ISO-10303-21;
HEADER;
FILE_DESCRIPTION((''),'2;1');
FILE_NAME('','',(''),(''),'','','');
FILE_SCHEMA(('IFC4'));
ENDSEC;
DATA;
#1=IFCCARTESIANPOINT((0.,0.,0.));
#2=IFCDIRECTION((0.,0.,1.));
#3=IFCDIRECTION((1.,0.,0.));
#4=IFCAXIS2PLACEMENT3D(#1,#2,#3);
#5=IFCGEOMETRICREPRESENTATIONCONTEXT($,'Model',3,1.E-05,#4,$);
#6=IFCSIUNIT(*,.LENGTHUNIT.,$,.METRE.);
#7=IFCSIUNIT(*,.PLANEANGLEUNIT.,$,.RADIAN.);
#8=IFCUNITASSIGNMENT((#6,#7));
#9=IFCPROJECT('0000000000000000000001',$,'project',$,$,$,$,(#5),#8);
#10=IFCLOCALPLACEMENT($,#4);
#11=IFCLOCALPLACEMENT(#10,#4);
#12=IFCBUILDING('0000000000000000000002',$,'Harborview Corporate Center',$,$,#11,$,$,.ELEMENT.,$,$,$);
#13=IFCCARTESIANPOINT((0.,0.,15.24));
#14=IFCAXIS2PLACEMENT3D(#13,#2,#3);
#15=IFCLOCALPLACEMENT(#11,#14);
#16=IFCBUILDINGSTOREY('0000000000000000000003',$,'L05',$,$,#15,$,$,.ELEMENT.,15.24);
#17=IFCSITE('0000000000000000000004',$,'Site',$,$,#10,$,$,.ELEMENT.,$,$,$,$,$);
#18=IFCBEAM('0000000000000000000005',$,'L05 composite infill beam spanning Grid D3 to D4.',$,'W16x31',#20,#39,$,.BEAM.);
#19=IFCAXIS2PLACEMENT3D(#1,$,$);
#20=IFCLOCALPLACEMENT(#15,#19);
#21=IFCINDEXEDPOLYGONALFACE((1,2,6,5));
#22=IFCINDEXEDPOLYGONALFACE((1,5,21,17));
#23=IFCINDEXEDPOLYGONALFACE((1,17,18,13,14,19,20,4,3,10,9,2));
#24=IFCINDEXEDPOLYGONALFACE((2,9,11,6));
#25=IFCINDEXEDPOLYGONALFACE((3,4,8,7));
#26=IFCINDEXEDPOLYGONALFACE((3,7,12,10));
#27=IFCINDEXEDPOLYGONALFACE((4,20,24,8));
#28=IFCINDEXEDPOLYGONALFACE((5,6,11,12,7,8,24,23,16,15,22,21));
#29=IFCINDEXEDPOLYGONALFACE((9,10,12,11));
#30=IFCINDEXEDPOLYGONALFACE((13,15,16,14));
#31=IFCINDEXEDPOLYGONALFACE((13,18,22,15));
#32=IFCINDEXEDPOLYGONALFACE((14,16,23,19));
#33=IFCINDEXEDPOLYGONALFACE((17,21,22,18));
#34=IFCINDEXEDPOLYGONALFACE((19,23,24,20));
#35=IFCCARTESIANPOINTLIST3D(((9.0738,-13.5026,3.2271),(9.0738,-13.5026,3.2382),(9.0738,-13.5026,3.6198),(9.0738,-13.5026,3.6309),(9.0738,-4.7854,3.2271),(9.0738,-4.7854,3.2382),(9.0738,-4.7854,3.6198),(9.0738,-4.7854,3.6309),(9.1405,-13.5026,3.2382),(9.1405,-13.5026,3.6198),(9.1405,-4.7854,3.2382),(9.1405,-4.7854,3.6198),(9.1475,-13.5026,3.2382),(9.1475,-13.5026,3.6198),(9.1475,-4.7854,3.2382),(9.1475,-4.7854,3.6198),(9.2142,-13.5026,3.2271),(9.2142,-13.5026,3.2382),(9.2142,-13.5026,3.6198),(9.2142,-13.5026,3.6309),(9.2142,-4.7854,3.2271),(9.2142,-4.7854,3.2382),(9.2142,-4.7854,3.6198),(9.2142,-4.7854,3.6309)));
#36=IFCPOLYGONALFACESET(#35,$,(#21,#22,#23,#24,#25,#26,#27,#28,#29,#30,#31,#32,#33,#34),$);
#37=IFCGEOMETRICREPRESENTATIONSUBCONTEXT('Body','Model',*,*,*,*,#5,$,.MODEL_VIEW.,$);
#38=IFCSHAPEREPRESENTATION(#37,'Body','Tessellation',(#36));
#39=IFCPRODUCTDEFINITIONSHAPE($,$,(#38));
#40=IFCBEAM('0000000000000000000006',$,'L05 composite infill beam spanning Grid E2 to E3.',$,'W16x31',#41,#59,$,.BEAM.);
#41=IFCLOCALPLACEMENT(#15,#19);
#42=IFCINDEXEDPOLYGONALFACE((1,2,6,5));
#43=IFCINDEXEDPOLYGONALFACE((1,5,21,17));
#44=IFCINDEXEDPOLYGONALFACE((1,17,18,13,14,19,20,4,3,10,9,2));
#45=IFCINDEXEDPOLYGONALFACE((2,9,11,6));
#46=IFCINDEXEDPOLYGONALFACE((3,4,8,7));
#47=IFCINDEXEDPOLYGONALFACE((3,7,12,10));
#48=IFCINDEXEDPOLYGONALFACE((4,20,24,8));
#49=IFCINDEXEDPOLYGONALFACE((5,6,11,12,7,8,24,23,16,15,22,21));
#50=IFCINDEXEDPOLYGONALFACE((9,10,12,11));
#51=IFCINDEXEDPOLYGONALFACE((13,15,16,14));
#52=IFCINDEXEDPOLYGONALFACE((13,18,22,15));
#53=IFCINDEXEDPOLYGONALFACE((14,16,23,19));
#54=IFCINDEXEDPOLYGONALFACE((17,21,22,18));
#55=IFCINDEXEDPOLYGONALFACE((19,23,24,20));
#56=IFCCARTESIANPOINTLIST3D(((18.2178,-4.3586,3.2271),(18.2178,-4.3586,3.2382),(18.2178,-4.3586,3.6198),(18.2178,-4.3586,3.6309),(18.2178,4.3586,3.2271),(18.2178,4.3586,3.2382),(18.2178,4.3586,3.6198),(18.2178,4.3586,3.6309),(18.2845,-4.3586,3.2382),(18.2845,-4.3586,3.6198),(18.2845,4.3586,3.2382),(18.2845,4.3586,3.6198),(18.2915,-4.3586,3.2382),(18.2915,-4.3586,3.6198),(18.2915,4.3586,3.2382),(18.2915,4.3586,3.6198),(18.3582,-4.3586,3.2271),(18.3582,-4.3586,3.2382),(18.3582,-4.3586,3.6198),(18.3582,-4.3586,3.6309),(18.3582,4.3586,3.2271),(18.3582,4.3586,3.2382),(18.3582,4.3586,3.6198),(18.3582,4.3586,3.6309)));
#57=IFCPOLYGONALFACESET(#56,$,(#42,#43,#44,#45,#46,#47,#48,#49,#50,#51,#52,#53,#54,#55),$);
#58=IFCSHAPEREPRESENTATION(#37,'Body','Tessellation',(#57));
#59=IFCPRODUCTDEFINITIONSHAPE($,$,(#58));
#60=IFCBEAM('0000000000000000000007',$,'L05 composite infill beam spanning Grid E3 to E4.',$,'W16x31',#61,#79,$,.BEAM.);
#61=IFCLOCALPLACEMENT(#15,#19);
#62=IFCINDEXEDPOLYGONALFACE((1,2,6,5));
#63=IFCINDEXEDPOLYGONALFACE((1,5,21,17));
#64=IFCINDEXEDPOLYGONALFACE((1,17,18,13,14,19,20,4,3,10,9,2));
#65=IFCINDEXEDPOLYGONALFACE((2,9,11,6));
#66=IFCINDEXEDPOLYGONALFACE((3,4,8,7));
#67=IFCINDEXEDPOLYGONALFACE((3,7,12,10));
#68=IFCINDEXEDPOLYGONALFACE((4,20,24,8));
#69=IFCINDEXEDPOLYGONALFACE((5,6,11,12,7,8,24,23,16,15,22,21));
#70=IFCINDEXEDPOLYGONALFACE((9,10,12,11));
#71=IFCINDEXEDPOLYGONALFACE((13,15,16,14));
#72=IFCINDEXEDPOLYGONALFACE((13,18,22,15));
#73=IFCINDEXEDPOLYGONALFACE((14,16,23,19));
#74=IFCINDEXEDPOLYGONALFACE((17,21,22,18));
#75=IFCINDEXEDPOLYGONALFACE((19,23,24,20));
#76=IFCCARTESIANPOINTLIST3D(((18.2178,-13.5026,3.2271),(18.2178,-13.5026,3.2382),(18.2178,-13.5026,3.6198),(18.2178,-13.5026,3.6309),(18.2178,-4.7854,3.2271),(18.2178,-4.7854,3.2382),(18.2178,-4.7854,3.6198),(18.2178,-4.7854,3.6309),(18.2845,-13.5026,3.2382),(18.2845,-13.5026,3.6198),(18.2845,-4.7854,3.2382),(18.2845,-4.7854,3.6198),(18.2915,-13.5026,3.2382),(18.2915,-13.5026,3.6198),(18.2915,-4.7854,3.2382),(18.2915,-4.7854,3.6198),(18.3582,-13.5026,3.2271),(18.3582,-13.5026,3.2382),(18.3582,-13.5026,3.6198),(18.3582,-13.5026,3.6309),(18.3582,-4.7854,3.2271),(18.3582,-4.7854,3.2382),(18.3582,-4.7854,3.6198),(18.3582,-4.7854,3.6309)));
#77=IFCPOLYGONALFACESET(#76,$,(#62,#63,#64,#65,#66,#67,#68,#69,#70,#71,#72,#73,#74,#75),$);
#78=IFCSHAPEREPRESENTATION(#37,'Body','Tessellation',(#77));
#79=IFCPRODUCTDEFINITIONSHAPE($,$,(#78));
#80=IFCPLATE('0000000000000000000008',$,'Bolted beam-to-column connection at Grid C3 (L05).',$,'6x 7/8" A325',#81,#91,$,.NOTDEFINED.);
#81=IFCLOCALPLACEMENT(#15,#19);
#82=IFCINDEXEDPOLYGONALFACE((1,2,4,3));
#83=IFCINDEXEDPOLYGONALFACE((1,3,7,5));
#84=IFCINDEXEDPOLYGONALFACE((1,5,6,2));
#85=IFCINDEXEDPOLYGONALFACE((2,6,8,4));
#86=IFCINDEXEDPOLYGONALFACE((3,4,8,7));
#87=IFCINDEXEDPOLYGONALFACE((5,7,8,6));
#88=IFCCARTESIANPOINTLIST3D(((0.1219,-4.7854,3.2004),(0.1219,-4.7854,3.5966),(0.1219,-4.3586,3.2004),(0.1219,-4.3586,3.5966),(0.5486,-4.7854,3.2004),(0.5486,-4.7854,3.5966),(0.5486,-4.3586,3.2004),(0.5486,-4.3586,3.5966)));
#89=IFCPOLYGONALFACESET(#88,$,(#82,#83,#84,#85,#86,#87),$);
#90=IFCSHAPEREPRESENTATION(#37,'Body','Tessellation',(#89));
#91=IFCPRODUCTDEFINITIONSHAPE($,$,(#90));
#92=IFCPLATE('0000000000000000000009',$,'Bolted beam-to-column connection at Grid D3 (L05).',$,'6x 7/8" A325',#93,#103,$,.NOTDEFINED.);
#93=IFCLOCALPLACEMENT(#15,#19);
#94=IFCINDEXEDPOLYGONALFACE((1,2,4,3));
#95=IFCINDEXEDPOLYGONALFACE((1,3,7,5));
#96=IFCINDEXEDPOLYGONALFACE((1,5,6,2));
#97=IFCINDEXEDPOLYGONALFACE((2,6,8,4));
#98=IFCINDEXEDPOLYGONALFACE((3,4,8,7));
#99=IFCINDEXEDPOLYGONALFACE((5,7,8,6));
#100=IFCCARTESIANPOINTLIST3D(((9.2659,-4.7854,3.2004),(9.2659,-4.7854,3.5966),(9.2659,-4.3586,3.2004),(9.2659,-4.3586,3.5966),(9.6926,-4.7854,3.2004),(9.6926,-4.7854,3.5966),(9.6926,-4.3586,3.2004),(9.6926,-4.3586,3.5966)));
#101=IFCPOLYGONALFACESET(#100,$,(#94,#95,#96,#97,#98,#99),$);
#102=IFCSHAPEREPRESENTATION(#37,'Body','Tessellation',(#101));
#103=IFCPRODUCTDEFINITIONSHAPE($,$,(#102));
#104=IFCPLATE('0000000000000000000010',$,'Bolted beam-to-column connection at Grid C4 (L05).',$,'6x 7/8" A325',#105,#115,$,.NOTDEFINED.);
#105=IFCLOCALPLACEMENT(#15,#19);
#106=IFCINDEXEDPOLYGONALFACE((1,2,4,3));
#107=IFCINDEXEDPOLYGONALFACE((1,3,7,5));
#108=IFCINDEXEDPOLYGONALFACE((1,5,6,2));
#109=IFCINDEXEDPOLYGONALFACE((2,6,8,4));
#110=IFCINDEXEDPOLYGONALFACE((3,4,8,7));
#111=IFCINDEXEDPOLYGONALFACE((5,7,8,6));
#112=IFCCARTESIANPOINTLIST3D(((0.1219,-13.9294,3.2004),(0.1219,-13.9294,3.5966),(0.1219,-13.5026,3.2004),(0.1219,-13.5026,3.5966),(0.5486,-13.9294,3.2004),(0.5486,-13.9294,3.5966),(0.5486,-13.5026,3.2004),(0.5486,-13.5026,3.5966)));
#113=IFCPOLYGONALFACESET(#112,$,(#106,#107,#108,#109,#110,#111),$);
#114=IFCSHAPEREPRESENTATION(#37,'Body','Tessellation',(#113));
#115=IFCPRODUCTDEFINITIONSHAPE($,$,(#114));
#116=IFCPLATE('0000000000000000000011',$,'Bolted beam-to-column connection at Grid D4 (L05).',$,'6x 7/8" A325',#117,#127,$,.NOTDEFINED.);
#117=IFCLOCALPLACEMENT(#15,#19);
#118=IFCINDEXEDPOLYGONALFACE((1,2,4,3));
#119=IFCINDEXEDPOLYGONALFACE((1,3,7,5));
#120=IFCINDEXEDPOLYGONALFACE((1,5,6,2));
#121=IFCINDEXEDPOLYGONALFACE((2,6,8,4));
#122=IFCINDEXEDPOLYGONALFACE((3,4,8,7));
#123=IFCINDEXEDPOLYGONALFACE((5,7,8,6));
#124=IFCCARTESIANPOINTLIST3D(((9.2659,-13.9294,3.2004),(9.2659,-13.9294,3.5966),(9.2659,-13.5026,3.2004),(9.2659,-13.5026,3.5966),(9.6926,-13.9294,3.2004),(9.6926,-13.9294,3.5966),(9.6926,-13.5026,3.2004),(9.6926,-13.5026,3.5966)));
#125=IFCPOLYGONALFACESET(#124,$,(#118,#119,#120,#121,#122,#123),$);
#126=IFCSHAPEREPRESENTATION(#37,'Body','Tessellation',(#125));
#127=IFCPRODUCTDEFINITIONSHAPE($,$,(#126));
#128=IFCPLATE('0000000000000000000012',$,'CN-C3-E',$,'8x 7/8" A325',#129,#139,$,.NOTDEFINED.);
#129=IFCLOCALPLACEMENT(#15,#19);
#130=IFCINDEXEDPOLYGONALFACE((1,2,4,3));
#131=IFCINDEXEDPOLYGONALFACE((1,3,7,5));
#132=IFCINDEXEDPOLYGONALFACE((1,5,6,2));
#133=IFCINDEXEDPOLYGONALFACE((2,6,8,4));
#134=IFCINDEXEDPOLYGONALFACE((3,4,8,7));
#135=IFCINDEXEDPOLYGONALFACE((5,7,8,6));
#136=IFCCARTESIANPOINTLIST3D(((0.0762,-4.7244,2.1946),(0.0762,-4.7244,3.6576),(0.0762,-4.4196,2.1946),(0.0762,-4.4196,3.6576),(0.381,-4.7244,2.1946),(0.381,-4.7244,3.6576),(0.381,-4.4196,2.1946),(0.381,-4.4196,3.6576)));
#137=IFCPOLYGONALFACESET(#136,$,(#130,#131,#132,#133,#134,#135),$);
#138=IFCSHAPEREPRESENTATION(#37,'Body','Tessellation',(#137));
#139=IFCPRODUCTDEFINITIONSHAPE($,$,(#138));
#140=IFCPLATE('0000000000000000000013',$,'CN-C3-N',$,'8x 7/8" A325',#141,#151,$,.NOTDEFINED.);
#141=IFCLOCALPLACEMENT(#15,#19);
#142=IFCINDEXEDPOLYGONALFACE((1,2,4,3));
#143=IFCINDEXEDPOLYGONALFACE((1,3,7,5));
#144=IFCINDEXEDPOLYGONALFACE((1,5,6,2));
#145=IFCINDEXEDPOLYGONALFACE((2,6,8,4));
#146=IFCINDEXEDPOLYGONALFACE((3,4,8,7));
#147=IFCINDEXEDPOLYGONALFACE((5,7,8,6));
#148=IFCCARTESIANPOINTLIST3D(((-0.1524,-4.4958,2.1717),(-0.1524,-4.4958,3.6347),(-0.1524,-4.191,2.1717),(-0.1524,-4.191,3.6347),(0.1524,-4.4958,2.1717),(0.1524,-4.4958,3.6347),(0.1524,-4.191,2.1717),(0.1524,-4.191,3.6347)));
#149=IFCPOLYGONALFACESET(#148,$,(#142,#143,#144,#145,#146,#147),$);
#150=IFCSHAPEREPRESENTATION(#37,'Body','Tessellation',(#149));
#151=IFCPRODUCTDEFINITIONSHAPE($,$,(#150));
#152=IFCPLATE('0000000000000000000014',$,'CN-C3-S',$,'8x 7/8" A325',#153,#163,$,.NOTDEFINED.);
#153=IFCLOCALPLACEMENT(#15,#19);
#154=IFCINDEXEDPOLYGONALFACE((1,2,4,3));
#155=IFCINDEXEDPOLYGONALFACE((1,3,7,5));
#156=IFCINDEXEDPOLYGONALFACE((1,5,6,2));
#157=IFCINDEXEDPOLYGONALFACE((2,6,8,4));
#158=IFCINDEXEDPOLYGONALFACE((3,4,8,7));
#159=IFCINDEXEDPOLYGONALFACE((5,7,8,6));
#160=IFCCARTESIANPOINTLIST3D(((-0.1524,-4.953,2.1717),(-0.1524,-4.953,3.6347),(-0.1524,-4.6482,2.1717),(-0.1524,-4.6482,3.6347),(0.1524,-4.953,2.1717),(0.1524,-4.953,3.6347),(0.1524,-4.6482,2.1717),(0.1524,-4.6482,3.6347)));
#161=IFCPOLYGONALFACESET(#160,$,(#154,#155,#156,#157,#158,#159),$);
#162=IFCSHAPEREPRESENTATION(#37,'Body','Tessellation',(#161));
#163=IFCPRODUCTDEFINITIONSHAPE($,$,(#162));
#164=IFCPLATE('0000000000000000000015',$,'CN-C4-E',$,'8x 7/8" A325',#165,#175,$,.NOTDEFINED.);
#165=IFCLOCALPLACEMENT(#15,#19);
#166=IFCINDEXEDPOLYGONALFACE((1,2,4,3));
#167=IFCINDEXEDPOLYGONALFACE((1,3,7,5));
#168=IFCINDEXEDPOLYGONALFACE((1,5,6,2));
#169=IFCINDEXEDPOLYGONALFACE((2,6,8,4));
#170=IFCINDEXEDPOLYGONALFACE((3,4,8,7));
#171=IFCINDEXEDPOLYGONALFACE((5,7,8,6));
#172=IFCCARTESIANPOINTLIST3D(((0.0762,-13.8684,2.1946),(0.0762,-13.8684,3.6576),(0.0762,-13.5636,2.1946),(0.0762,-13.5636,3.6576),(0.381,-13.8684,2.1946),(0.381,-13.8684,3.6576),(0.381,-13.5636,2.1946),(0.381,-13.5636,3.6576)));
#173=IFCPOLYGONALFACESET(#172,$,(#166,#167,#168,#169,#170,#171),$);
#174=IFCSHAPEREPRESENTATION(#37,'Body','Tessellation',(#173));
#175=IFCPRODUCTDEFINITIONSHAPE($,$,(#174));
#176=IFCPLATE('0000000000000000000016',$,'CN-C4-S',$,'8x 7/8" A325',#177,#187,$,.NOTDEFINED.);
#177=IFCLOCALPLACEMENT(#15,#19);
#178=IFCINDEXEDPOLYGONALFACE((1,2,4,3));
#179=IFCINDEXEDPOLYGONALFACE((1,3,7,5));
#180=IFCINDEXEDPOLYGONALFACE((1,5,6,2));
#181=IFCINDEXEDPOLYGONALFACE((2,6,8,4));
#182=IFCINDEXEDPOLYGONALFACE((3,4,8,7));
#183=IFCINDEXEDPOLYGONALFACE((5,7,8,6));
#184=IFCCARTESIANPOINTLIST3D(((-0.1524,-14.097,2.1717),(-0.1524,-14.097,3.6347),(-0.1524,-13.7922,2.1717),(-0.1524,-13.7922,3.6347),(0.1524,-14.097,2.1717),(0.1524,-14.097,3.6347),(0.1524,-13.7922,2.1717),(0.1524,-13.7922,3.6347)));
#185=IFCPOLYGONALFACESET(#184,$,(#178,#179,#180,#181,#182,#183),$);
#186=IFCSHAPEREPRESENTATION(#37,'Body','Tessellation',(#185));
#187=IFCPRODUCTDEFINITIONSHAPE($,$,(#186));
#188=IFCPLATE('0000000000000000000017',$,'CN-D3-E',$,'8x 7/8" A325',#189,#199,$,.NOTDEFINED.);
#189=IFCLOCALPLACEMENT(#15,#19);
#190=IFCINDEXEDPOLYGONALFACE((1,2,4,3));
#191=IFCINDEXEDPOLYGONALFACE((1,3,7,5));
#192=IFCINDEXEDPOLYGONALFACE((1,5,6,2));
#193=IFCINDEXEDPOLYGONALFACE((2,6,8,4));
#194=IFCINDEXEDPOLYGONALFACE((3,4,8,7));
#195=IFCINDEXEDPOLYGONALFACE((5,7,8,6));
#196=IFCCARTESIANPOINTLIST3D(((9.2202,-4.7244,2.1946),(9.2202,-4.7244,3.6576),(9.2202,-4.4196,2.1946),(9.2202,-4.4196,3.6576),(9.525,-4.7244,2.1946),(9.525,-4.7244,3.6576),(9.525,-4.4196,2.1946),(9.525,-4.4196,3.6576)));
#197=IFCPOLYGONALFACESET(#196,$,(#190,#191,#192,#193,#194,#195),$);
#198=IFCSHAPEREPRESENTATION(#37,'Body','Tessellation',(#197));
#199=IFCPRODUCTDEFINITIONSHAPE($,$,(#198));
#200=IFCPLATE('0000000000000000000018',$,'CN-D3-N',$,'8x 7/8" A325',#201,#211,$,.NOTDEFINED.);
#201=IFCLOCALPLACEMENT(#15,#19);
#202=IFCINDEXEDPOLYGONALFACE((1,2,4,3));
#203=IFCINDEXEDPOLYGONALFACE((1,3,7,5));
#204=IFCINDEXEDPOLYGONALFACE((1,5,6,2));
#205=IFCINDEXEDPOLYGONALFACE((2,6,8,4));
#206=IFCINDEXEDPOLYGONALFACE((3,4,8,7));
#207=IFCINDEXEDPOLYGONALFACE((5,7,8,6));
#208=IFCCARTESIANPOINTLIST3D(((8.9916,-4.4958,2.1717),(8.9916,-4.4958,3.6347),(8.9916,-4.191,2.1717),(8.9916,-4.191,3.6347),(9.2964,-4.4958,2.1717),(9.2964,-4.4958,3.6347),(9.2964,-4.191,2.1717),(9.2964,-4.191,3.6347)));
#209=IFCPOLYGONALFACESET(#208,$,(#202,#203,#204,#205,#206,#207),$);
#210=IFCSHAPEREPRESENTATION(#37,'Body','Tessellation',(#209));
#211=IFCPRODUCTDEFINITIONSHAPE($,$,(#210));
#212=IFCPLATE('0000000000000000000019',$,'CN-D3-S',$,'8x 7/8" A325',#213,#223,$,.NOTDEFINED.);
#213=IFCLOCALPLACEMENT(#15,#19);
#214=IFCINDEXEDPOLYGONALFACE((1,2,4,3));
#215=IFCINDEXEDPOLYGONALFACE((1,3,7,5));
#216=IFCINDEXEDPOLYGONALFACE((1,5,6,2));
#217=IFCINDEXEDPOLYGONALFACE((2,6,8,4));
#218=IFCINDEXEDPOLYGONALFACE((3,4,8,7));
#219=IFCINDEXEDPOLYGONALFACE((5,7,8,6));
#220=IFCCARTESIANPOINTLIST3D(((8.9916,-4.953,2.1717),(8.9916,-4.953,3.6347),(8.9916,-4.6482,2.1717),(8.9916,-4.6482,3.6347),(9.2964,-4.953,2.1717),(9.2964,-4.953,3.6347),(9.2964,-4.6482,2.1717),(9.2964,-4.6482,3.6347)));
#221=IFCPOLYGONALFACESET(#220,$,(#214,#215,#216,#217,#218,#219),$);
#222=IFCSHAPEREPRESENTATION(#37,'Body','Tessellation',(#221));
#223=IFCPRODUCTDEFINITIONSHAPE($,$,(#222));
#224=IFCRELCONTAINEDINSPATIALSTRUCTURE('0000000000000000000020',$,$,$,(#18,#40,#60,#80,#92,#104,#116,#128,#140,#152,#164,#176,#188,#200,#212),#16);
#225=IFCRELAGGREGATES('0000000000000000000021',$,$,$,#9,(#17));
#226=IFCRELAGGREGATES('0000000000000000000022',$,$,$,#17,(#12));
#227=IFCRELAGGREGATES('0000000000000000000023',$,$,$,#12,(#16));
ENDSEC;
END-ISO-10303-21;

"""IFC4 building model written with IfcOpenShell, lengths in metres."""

from ifc_helpers import new_model, si_unit, frame, origin_with_axes, place, context, subcontext, project, spatial, rectangle, i_section, extrude, element, save


model = new_model("IFC4")

# Units and contexts
model_context = context("Model", 3, precision=1e-05, world=origin_with_axes())
body_context = subcontext(model_context, "Body", "Model", "MODEL_VIEW")
ifc_project = project(units=[si_unit("LENGTHUNIT", "METRE"), si_unit("PLANEANGLEUNIT", "RADIAN")], contexts=[model_context])

# Site, building, storey
site_placement = place(None, origin_with_axes())
site = spatial("IfcSite", under=ifc_project, at=site_placement, Name="Site", CompositionType="ELEMENT")
building_placement = place(site_placement, origin_with_axes())
building = spatial("IfcBuilding", under=site, at=building_placement, Name="Harborview Corporate Center", CompositionType="ELEMENT")
storey_placement = place(building_placement, frame((0.0, 0.0, 15.24), z_axis=(0.0, 0.0, 1.0), x_axis=(1.0, 0.0, 0.0)))
storey = spatial("IfcBuildingStorey", under=building, at=storey_placement, Name="L05", CompositionType="ELEMENT", Elevation=15.24)

# Beams
beam_1_placement = place(storey_placement, frame((9.144, -13.5026, 3.429), z_axis=(0.0, 1.0, 0.0), x_axis=(-1.0, 0.0, 0.0)))
element("IfcBeam", 1, at=beam_1_placement, inside=storey, Name="L05 composite infill beam spanning Grid D3 to D4.", ObjectType="W16x31", PredefinedType="BEAM", context=body_context, shape_type="SweptSolid", body=[
    extrude(i_section(OverallWidth=0.1405, OverallDepth=0.4039, WebThickness=0.007, FlangeThickness=0.0112), origin_with_axes(), (0.0, 0.0, 1.0), 8.7173),
])
beam_2_placement = place(storey_placement, frame((18.288, -4.3586, 3.429), z_axis=(0.0, 1.0, 0.0), x_axis=(-1.0, 0.0, 0.0)))
element("IfcBeam", 2, at=beam_2_placement, inside=storey, Name="L05 composite infill beam spanning Grid E2 to E3.", ObjectType="W16x31", PredefinedType="BEAM", context=body_context, shape_type="SweptSolid", body=[
    extrude(i_section(OverallWidth=0.1405, OverallDepth=0.4039, WebThickness=0.007, FlangeThickness=0.0112), origin_with_axes(), (0.0, 0.0, 1.0), 8.7173),
])
beam_3_placement = place(storey_placement, frame((18.288, -13.5026, 3.429), z_axis=(0.0, 1.0, 0.0), x_axis=(-1.0, 0.0, 0.0)))
element("IfcBeam", 3, at=beam_3_placement, inside=storey, Name="L05 composite infill beam spanning Grid E3 to E4.", ObjectType="W16x31", PredefinedType="BEAM", context=body_context, shape_type="SweptSolid", body=[
    extrude(i_section(OverallWidth=0.1405, OverallDepth=0.4039, WebThickness=0.007, FlangeThickness=0.0112), origin_with_axes(), (0.0, 0.0, 1.0), 8.7173),
])

# Plates
plate_1_placement = place(storey_placement, frame((0.3353, -4.572, 3.2004), z_axis=(0.0, 0.0, 1.0), x_axis=(1.0, 0.0, 0.0)))
element("IfcPlate", 4, at=plate_1_placement, inside=storey, Name="Bolted beam-to-column connection at Grid C3 (L05).", ObjectType="6x 7/8\" A325", PredefinedType="NOTDEFINED", context=body_context, shape_type="SweptSolid", body=[
    extrude(rectangle(XDim=0.4267, YDim=0.4267), origin_with_axes(), (0.0, 0.0, 1.0), 0.3962),
])
plate_2_placement = place(storey_placement, frame((9.4793, -4.572, 3.2004), z_axis=(0.0, 0.0, 1.0), x_axis=(1.0, 0.0, 0.0)))
element("IfcPlate", 5, at=plate_2_placement, inside=storey, Name="Bolted beam-to-column connection at Grid D3 (L05).", ObjectType="6x 7/8\" A325", PredefinedType="NOTDEFINED", context=body_context, shape_type="SweptSolid", body=[
    extrude(rectangle(XDim=0.4267, YDim=0.4267), origin_with_axes(), (0.0, 0.0, 1.0), 0.3962),
])
plate_3_placement = place(storey_placement, frame((0.3353, -13.716, 3.2004), z_axis=(0.0, 0.0, 1.0), x_axis=(1.0, 0.0, 0.0)))
element("IfcPlate", 6, at=plate_3_placement, inside=storey, Name="Bolted beam-to-column connection at Grid C4 (L05).", ObjectType="6x 7/8\" A325", PredefinedType="NOTDEFINED", context=body_context, shape_type="SweptSolid", body=[
    extrude(rectangle(XDim=0.4267, YDim=0.4267), origin_with_axes(), (0.0, 0.0, 1.0), 0.3962),
])
plate_4_placement = place(storey_placement, frame((9.4793, -13.716, 3.2004), z_axis=(0.0, 0.0, 1.0), x_axis=(1.0, 0.0, 0.0)))
element("IfcPlate", 7, at=plate_4_placement, inside=storey, Name="Bolted beam-to-column connection at Grid D4 (L05).", ObjectType="6x 7/8\" A325", PredefinedType="NOTDEFINED", context=body_context, shape_type="SweptSolid", body=[
    extrude(rectangle(XDim=0.4267, YDim=0.4267), origin_with_axes(), (0.0, 0.0, 1.0), 0.3962),
])
for number, where, z_axis, x_axis, name in (
    (8, (0.2286, -4.572, 2.1946), (0.0, 0.0, 1.0), (1.0, 0.0, 0.0), "CN-C3-E"),
    (9, (0.0, -4.3434, 2.1717), (0.0, 0.0, 1.0), (1.0, 0.0, 0.0), "CN-C3-N"),
    (10, (0.0, -4.8006, 2.1717), (0.0, 0.0, 1.0), (1.0, 0.0, 0.0), "CN-C3-S"),
    (11, (0.2286, -13.716, 2.1946), (0.0, 0.0, 1.0), (1.0, 0.0, 0.0), "CN-C4-E"),
    (12, (0.0, -13.9446, 2.1717), (0.0, 0.0, 1.0), (1.0, 0.0, 0.0), "CN-C4-S"),
):
    element("IfcPlate", number, at=place(storey_placement, frame(where, z_axis=z_axis, x_axis=x_axis)), inside=storey, Name=name, ObjectType="8x 7/8\" A325", PredefinedType="NOTDEFINED", context=body_context, shape_type="SweptSolid", body=[
        extrude(rectangle(XDim=0.3048, YDim=0.3048), origin_with_axes(), (0.0, 0.0, 1.0), 1.463),
    ])
for number, where, z_axis, x_axis, name in (
    (13, (9.3726, -4.572, 2.1946), (0.0, 0.0, 1.0), (1.0, 0.0, 0.0), "CN-D3-E"),
    (14, (9.144, -4.3434, 2.1717), (0.0, 0.0, 1.0), (1.0, 0.0, 0.0), "CN-D3-N"),
    (15, (9.144, -4.8006, 2.1717), (0.0, 0.0, 1.0), (1.0, 0.0, 0.0), "CN-D3-S"),
):
    element("IfcPlate", number, at=place(storey_placement, frame(where, z_axis=z_axis, x_axis=x_axis)), inside=storey, Name=name, ObjectType="8x 7/8\" A325", PredefinedType="NOTDEFINED", context=body_context, shape_type="SweptSolid", body=[
        extrude(rectangle(XDim=0.3048, YDim=0.3048), origin_with_axes(), (0.0, 0.0, 1.0), 1.463),
    ])

save(model, "model.ifc")
